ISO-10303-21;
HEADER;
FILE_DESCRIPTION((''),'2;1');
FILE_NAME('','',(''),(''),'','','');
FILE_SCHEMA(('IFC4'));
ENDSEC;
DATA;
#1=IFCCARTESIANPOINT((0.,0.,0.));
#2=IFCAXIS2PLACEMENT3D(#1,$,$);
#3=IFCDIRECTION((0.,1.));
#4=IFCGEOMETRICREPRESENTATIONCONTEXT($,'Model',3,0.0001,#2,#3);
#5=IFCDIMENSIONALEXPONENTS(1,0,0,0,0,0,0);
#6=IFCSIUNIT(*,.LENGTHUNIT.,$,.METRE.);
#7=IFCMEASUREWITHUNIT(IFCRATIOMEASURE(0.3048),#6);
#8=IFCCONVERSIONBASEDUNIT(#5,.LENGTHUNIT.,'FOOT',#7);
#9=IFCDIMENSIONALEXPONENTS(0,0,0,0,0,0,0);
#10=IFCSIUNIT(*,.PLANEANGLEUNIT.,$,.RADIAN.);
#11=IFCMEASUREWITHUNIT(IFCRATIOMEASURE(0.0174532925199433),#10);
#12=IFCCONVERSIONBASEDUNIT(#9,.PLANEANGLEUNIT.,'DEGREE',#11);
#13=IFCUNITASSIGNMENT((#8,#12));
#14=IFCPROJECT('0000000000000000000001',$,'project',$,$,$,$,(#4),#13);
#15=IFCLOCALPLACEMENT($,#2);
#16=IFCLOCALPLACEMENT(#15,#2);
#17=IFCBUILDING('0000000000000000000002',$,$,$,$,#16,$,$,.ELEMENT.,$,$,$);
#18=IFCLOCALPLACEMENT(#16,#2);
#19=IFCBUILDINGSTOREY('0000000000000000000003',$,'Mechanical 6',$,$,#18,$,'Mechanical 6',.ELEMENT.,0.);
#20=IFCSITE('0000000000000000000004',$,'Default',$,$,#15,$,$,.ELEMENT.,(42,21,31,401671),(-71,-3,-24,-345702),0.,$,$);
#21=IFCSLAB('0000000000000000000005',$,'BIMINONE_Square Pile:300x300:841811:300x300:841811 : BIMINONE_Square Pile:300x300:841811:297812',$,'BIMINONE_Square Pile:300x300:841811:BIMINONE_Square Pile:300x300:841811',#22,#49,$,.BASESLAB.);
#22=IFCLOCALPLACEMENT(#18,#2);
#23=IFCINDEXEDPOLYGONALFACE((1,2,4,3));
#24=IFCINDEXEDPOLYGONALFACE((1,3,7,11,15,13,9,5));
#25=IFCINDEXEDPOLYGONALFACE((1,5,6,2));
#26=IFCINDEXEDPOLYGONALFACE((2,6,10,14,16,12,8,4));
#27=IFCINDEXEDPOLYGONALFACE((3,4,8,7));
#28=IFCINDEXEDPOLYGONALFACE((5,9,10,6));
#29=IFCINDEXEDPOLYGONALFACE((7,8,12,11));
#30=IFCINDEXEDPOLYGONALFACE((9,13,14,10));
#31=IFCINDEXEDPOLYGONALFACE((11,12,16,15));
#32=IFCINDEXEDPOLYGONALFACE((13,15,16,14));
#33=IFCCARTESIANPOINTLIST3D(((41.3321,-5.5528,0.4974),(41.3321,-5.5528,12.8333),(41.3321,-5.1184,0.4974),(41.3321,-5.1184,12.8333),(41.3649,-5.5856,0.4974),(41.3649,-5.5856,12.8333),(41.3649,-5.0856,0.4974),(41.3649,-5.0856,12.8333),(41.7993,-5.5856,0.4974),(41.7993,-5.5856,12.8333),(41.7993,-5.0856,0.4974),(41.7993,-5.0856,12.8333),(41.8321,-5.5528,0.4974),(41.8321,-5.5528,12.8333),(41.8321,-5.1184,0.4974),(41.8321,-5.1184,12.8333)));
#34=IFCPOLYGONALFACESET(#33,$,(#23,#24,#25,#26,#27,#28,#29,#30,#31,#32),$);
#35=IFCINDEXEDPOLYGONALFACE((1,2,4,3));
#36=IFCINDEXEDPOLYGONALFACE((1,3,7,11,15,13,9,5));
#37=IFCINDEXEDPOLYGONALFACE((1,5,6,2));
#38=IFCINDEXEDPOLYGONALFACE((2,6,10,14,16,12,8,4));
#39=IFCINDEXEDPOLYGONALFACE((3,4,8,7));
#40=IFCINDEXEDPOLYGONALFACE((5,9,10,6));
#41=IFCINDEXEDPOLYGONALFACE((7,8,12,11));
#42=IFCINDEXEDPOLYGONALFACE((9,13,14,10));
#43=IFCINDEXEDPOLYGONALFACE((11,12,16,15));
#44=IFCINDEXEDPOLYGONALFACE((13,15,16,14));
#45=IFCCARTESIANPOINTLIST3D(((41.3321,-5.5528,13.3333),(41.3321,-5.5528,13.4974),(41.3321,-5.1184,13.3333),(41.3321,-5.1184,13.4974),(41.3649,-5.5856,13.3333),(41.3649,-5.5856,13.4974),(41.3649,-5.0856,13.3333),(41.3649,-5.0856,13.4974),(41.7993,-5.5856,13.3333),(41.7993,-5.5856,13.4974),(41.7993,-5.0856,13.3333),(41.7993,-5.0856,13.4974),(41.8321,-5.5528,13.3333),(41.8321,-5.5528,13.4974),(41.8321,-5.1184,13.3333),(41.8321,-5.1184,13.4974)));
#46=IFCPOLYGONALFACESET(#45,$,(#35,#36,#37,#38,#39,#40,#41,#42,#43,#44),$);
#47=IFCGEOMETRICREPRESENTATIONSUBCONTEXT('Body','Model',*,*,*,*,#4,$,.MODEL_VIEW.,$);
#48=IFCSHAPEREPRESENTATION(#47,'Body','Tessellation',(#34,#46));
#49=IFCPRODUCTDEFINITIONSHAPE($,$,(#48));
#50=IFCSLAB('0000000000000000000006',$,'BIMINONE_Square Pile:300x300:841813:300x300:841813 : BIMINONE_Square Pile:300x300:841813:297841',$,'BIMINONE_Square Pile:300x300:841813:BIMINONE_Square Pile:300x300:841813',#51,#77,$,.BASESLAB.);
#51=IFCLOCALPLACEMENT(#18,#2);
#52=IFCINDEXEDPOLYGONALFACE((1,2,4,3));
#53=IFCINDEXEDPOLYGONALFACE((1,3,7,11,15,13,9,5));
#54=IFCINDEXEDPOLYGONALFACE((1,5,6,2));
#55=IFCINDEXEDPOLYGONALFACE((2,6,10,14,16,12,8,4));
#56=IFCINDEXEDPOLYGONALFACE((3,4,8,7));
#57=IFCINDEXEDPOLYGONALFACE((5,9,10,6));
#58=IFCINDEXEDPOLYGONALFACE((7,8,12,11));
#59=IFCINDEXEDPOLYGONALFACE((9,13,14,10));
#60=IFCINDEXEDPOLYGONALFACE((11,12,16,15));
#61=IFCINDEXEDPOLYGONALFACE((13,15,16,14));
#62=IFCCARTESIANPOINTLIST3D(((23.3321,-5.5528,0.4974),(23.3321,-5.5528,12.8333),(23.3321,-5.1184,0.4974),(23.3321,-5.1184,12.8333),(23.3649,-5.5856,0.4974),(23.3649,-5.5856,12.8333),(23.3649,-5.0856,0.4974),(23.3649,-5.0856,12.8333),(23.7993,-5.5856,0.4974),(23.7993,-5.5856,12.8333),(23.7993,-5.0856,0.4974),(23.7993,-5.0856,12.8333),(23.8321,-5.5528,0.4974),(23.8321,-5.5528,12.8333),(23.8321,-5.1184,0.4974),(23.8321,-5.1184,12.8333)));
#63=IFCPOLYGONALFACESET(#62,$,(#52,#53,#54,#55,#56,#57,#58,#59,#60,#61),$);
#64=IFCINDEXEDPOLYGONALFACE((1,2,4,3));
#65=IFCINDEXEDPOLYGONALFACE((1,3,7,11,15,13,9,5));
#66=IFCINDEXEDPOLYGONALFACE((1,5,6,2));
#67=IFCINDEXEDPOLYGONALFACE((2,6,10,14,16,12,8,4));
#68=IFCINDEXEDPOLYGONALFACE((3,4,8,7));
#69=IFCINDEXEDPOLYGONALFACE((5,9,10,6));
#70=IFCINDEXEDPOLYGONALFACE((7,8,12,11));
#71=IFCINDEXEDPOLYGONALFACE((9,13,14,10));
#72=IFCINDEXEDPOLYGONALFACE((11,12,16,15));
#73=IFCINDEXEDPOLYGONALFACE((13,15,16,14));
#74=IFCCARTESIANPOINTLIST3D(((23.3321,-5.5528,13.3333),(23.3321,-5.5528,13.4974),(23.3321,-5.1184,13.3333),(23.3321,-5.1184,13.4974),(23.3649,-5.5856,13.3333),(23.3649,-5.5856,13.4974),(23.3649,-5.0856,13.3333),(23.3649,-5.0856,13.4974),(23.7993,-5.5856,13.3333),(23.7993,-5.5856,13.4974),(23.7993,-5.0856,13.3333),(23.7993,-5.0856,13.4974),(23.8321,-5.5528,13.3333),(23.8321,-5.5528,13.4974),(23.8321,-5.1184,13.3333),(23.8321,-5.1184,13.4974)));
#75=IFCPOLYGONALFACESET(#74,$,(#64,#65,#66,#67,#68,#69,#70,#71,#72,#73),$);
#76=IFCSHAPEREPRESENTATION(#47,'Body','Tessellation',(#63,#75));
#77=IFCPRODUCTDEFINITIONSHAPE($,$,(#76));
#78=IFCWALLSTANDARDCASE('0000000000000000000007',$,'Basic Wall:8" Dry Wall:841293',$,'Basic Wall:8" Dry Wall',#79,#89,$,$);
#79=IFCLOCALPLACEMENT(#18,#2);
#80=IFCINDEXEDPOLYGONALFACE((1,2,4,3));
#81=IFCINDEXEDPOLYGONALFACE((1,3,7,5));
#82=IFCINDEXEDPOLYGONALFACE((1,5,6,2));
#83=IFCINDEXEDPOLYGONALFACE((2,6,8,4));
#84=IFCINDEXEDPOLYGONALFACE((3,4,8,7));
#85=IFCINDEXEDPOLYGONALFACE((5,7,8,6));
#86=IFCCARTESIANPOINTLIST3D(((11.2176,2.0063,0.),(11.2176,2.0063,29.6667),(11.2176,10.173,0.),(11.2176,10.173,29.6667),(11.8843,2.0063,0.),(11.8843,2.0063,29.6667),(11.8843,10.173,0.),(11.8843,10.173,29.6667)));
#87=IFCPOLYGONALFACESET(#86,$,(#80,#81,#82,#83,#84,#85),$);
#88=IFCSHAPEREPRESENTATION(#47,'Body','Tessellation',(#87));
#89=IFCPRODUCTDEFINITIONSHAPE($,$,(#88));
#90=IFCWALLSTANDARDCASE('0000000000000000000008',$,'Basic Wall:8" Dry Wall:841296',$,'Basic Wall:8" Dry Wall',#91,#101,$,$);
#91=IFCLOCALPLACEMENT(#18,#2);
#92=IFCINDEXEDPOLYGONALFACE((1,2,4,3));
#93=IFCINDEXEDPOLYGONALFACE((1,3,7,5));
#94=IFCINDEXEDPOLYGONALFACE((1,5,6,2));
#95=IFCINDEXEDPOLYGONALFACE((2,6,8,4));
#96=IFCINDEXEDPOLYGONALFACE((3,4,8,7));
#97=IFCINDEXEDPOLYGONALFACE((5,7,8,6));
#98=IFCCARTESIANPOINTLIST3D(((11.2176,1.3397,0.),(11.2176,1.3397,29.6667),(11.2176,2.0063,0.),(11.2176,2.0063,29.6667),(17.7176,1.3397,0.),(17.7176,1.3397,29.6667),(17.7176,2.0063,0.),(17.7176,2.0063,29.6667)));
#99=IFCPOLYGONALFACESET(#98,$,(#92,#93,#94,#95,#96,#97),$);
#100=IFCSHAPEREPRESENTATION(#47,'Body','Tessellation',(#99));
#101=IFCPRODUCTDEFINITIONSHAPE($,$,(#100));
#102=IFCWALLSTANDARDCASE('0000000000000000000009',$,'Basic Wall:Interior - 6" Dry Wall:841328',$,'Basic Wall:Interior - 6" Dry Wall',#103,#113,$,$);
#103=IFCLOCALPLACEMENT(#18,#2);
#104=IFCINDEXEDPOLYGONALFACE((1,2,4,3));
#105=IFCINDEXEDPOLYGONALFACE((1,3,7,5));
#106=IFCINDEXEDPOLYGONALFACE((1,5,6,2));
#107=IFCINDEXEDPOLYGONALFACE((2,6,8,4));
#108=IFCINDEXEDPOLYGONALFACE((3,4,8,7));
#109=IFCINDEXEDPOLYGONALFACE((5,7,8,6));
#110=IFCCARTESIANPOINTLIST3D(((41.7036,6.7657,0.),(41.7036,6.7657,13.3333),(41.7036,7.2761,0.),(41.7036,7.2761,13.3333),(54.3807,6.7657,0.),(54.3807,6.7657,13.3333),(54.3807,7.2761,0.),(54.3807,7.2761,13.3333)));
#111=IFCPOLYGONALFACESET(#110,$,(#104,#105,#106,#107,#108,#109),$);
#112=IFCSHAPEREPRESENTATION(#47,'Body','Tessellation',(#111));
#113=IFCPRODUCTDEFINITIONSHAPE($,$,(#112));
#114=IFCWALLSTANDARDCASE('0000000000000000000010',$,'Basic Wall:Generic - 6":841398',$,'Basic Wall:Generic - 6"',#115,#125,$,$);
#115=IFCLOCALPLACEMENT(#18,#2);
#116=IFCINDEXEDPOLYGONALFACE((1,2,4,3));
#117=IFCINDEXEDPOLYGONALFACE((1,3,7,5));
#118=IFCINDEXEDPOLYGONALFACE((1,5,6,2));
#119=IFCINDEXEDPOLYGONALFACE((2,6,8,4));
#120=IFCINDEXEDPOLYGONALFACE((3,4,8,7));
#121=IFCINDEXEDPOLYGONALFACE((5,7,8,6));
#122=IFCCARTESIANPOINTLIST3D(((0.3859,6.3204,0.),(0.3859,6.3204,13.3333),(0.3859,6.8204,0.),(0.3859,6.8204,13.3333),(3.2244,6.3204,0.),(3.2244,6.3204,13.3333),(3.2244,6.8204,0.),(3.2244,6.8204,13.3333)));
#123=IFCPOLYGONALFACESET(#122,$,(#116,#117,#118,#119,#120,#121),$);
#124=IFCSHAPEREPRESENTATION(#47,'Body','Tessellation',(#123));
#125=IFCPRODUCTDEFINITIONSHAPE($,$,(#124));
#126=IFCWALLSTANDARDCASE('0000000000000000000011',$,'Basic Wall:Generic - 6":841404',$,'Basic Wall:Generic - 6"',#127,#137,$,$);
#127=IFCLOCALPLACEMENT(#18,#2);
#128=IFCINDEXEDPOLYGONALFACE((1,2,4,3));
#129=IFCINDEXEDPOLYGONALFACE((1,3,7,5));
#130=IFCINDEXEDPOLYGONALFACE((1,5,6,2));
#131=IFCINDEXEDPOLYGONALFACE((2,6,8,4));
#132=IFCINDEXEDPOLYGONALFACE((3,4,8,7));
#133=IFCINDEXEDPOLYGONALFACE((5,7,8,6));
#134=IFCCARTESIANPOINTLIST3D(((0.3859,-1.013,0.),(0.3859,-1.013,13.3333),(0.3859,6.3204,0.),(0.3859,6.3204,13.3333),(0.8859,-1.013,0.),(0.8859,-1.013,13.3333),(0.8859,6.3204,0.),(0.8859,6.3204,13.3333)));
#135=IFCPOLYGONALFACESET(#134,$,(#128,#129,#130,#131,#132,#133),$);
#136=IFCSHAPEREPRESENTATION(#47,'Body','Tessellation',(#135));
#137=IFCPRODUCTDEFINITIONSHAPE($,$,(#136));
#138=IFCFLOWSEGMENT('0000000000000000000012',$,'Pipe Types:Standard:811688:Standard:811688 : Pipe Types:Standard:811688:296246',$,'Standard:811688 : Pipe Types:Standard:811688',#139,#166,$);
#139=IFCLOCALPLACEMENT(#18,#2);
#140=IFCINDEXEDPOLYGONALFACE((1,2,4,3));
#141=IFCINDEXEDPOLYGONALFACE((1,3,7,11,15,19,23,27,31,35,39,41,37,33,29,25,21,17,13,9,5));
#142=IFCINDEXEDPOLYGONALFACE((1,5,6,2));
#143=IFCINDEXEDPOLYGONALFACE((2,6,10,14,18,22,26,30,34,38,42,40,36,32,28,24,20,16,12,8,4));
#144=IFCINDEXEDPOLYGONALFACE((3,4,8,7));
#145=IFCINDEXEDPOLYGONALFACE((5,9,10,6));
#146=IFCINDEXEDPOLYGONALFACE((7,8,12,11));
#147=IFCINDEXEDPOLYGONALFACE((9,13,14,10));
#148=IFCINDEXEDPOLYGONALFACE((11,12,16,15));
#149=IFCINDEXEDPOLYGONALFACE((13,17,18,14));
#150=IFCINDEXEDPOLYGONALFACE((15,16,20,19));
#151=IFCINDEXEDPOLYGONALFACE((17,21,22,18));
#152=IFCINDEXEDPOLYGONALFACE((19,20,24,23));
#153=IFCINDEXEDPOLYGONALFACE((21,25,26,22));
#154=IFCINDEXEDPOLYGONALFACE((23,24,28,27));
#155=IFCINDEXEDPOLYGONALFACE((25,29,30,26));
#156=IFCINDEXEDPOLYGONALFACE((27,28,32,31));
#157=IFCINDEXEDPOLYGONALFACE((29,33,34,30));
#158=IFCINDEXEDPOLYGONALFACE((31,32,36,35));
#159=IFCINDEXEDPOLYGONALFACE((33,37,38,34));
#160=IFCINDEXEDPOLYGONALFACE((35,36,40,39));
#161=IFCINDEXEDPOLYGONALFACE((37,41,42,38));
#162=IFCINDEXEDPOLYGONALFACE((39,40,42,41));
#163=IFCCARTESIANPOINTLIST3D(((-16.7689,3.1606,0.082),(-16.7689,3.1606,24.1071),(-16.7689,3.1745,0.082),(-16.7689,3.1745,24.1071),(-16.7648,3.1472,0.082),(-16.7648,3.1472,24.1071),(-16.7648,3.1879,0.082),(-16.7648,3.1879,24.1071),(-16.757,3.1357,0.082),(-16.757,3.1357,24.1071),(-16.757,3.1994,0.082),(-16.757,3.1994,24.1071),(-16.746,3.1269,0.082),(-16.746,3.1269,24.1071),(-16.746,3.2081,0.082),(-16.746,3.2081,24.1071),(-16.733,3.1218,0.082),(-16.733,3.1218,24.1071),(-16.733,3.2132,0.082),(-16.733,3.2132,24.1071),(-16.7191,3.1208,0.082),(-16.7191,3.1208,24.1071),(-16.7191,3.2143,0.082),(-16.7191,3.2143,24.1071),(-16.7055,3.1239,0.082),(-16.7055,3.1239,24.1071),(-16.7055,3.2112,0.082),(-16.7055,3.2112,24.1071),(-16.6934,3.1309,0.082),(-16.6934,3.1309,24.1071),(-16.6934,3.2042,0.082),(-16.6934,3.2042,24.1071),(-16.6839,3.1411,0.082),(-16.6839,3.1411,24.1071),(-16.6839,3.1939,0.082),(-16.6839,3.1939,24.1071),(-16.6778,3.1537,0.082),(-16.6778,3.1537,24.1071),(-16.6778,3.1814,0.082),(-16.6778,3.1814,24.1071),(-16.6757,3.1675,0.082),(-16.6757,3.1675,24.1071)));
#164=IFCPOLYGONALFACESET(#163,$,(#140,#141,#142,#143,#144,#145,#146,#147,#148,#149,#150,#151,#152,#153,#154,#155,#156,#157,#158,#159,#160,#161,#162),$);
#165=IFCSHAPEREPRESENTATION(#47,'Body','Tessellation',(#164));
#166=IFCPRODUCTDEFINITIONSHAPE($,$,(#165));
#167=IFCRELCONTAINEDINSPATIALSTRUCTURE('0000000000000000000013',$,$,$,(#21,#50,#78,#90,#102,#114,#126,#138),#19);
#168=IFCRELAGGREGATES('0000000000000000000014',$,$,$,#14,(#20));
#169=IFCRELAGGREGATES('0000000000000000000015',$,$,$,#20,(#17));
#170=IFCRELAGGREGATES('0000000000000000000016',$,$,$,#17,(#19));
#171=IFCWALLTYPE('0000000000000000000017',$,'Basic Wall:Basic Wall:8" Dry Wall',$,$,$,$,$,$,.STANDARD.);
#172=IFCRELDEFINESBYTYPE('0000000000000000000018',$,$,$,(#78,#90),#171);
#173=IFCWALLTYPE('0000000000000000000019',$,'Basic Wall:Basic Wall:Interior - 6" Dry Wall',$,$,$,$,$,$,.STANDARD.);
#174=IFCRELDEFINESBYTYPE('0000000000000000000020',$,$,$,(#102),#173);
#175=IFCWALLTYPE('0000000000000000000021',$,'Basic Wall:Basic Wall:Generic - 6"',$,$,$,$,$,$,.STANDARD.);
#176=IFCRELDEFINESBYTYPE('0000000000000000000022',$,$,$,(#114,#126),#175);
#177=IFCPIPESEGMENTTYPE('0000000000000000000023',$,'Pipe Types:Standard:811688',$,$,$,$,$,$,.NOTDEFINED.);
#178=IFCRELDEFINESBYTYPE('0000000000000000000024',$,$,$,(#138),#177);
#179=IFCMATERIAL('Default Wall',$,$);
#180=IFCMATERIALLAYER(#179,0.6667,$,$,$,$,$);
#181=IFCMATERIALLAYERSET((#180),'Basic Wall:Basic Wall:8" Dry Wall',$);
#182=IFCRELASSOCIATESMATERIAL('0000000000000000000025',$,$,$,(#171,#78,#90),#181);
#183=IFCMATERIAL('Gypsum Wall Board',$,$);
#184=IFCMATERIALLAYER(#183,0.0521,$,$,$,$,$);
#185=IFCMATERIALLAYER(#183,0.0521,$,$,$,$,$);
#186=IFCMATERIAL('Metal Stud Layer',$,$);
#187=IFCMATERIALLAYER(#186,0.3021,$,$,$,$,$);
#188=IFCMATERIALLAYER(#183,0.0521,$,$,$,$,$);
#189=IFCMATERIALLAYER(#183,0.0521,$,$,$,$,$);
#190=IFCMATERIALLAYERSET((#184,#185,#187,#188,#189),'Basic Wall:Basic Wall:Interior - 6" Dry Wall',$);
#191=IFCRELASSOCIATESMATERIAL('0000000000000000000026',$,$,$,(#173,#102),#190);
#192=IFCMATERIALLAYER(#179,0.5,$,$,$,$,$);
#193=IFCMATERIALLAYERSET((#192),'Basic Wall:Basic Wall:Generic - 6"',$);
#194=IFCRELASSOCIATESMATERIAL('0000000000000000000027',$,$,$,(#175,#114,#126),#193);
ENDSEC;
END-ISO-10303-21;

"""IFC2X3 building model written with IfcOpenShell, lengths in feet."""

from ifc_helpers import new_model, entity, si_unit, converted_unit, direction, frame, frame_2d, origin, origin_2d_with_axis, place, context, subcontext, project, spatial, polyline, rectangle, circle, outline, extrude, source, transform, mapped, material, layer, layer_set, layer_usage, type_object, type_shapes, element, save


model = new_model("IFC2X3")

# Units and contexts
model_context = context("Model", 3, precision=0.0001, world=origin(), true_north=direction((0.0, 1.0)))
body_context = subcontext(model_context, "Body", "Model", "MODEL_VIEW")
ifc_project = project(units=[converted_unit("LENGTHUNIT", "FOOT", entity("IfcRatioMeasure", 0.3048), si_unit("LENGTHUNIT", "METRE"), dimensions=[1, 0, 0, 0, 0, 0, 0]), converted_unit("PLANEANGLEUNIT", "DEGREE", entity("IfcRatioMeasure", 0.0174532925199433), si_unit("PLANEANGLEUNIT", "RADIAN"), dimensions=[0, 0, 0, 0, 0, 0, 0])], contexts=[model_context])

# Site, building, storey
site_placement = place(None, origin())
site = spatial("IfcSite", under=ifc_project, at=site_placement, Name="Default", CompositionType="ELEMENT", RefLatitude=(42, 21, 31, 401671), RefLongitude=(-71, -3, -24, -345702), RefElevation=0.0)
building_placement = place(site_placement, origin())
building = spatial("IfcBuilding", under=site, at=building_placement, CompositionType="ELEMENT")
storey_placement = place(building_placement, origin())
storey = spatial("IfcBuildingStorey", under=building, at=storey_placement, Name="Mechanical 6", LongName="Mechanical 6", CompositionType="ELEMENT", Elevation=0.0)

# Slabs
slab_1_placement = place(building_placement, origin())
element("IfcSlab", 1, at=slab_1_placement, inside=storey, Name="BIMINONE_Square Pile:300x300:841811:300x300:841811 : BIMINONE_Square Pile:300x300:841811:297812", ObjectType="BIMINONE_Square Pile:300x300:841811:BIMINONE_Square Pile:300x300:841811", PredefinedType="BASESLAB", context=body_context, shape_type="SweptSolid", body=[
    extrude(outline(polyline([(-0.0232, -0.3304), (0.0232, -0.3304), (0.3304, -0.0232), (0.3304, 0.0232), (0.0232, 0.3304), (-0.0232, 0.3304), (-0.3304, 0.0232), (-0.3304, -0.0232), (-0.0232, -0.3304)])), frame((41.5821, -5.3356, 0.4974), z_axis=(0.0, 0.0, 1.0), x_axis=(0.707107, -0.707107, 0.0)), (0.0, 0.0, 1.0), 12.336),
    extrude(outline(polyline([(-0.2172, -0.25), (0.2172, -0.25), (0.25, -0.2172), (0.25, 0.2172), (0.2172, 0.25), (-0.2172, 0.25), (-0.25, 0.2172), (-0.25, -0.2172), (-0.2172, -0.25)])), frame((41.5821, -5.3356, 13.3333)), (0.0, 0.0, 1.0), 0.164),
])
slab_2_placement = place(building_placement, origin())
element("IfcSlab", 2, at=slab_2_placement, inside=storey, Name="BIMINONE_Square Pile:300x300:841813:300x300:841813 : BIMINONE_Square Pile:300x300:841813:297841", ObjectType="BIMINONE_Square Pile:300x300:841813:BIMINONE_Square Pile:300x300:841813", PredefinedType="BASESLAB", context=body_context, shape_type="SweptSolid", body=[
    extrude(outline(polyline([(-0.0232, -0.3304), (0.0232, -0.3304), (0.3304, -0.0232), (0.3304, 0.0232), (0.0232, 0.3304), (-0.0232, 0.3304), (-0.3304, 0.0232), (-0.3304, -0.0232), (-0.0232, -0.3304)])), frame((23.5821, -5.3356, 0.4974), z_axis=(0.0, 0.0, 1.0), x_axis=(0.707107, -0.707107, 0.0)), (0.0, 0.0, 1.0), 12.336),
    extrude(outline(polyline([(-0.2172, -0.25), (0.2172, -0.25), (0.25, -0.2172), (0.25, 0.2172), (0.2172, 0.25), (-0.2172, 0.25), (-0.25, 0.2172), (-0.25, -0.2172), (-0.2172, -0.25)])), frame((23.5821, -5.3356, 13.3333)), (0.0, 0.0, 1.0), 0.164),
])

# Walls
ifc_material_1 = material(Name="Default Wall")
ifc_layer_1 = layer(ifc_material_1, 0.6667)
ifc_layer_set_1 = layer_set([ifc_layer_1], Name="Basic Wall:Basic Wall:8\" Dry Wall")
ifc_layer_usage_1 = layer_usage(ifc_layer_set_1, "AXIS2", "NEGATIVE", 0.3333)
wall_type_1 = type_object("IfcWallType", Name="Basic Wall:Basic Wall:8\" Dry Wall", PredefinedType="STANDARD", material=ifc_layer_set_1)
wall_1_placement = place(storey_placement, frame((11.5509, 2.0063, 0.0), z_axis=(0.0, 0.0, 1.0), x_axis=(0.0, 1.0, 0.0)))
element("IfcWallStandardCase", 3, at=wall_1_placement, inside=storey, type_object=wall_type_1, material=ifc_layer_usage_1, Name="Basic Wall:8\" Dry Wall:841293", ObjectType="Basic Wall:8\" Dry Wall", context=body_context, shape_type="SweptSolid", body=[
    extrude(rectangle(XDim=8.1667, YDim=0.6667, at=frame_2d((4.0833, 0.0), x_axis=(-1.0, 0.0))), origin(), (0.0, 0.0, 1.0), 29.6667),
])
ifc_layer_usage_2 = layer_usage(ifc_layer_set_1, "AXIS2", "NEGATIVE", 0.3333)
wall_2_placement = place(storey_placement, frame((17.7176, 1.673, 0.0), z_axis=(0.0, 0.0, 1.0), x_axis=(-1.0, 0.0, 0.0)))
element("IfcWallStandardCase", 4, at=wall_2_placement, inside=storey, type_object=wall_type_1, material=ifc_layer_usage_2, Name="Basic Wall:8\" Dry Wall:841296", ObjectType="Basic Wall:8\" Dry Wall", context=body_context, shape_type="SweptSolid", body=[
    extrude(rectangle(XDim=6.5, YDim=0.6667, at=frame_2d((3.25, 0.0), x_axis=(-1.0, 0.0))), origin(), (0.0, 0.0, 1.0), 29.6667),
])
ifc_material_2 = material(Name="Gypsum Wall Board")
ifc_layer_2 = layer(ifc_material_2, 0.0521)
ifc_layer_3 = layer(ifc_material_2, 0.0521)
ifc_material_3 = material(Name="Metal Stud Layer")
ifc_layer_4 = layer(ifc_material_3, 0.3021)
ifc_layer_5 = layer(ifc_material_2, 0.0521)
ifc_layer_6 = layer(ifc_material_2, 0.0521)
ifc_layer_set_2 = layer_set([ifc_layer_2, ifc_layer_3, ifc_layer_4, ifc_layer_5, ifc_layer_6], Name="Basic Wall:Basic Wall:Interior - 6\" Dry Wall")
ifc_layer_usage_3 = layer_usage(ifc_layer_set_2, "AXIS2", "NEGATIVE", 0.2552)
wall_type_2 = type_object("IfcWallType", Name="Basic Wall:Basic Wall:Interior - 6\" Dry Wall", PredefinedType="STANDARD", material=ifc_layer_set_2)
wall_3_placement = place(storey_placement, frame((54.3807, 7.0209, 0.0), z_axis=(0.0, 0.0, 1.0), x_axis=(-1.0, 0.0, 0.0)))
element("IfcWallStandardCase", 5, at=wall_3_placement, inside=storey, type_object=wall_type_2, material=ifc_layer_usage_3, Name="Basic Wall:Interior - 6\" Dry Wall:841328", ObjectType="Basic Wall:Interior - 6\" Dry Wall", context=body_context, shape_type="SweptSolid", body=[
    extrude(rectangle(XDim=12.6771, YDim=0.5104, at=frame_2d((6.3385, 0.0), x_axis=(-1.0, 0.0))), origin(), (0.0, 0.0, 1.0), 13.3333),
])
ifc_layer_7 = layer(ifc_material_1, 0.5)
ifc_layer_set_3 = layer_set([ifc_layer_7], Name="Basic Wall:Basic Wall:Generic - 6\"")
ifc_layer_usage_4 = layer_usage(ifc_layer_set_3, "AXIS2", "NEGATIVE", 0.25)
wall_type_3 = type_object("IfcWallType", Name="Basic Wall:Basic Wall:Generic - 6\"", PredefinedType="STANDARD", material=ifc_layer_set_3)
wall_4_placement = place(storey_placement, frame((3.2244, 6.5704, 0.0), z_axis=(0.0, 0.0, 1.0), x_axis=(-1.0, 0.0, 0.0)))
element("IfcWallStandardCase", 6, at=wall_4_placement, inside=storey, type_object=wall_type_3, material=ifc_layer_usage_4, Name="Basic Wall:Generic - 6\":841398", ObjectType="Basic Wall:Generic - 6\"", context=body_context, shape_type="SweptSolid", body=[
    extrude(rectangle(XDim=2.8385, YDim=0.5, at=frame_2d((1.4193, 0.0), x_axis=(-1.0, 0.0))), origin(), (0.0, 0.0, 1.0), 13.3333),
])
ifc_layer_usage_5 = layer_usage(ifc_layer_set_3, "AXIS2", "NEGATIVE", 0.25)
wall_5_placement = place(storey_placement, frame((0.6359, 6.3204, 0.0), z_axis=(0.0, 0.0, 1.0), x_axis=(0.0, -1.0, 0.0)))
element("IfcWallStandardCase", 7, at=wall_5_placement, inside=storey, type_object=wall_type_3, material=ifc_layer_usage_5, Name="Basic Wall:Generic - 6\":841404", ObjectType="Basic Wall:Generic - 6\"", context=body_context, shape_type="SweptSolid", body=[
    extrude(rectangle(XDim=7.3333, YDim=0.5, at=frame_2d((3.6667, 0.0), x_axis=(-1.0, 0.0))), origin(), (0.0, 0.0, 1.0), 13.3333),
])

# Flow segment
pipe_segment_type_1 = type_object("IfcPipeSegmentType", Name="Pipe Types:Standard:811688", PredefinedType="NOTDEFINED")
shared_shape_1 = source(origin(), body_context, "Body", "SweptSolid", [
    extrude(circle(Radius=0.0469, at=origin_2d_with_axis()), frame((-16.7226, 3.1675, 0.082)), (0.0, 0.0, 1.0), 24.0251),
])
type_shapes(pipe_segment_type_1, [shared_shape_1])
flow_segment_1_placement = place(building_placement, origin())
element("IfcFlowSegment", 8, at=flow_segment_1_placement, inside=storey, type_object=pipe_segment_type_1, Name="Pipe Types:Standard:811688:Standard:811688 : Pipe Types:Standard:811688:296246", ObjectType="Standard:811688 : Pipe Types:Standard:811688", context=body_context, shape_type="MappedRepresentation", body=[
    mapped(shared_shape_1, transform((0.0, 0.0, 0.0), scale=1.0)),
])

save(model, "model.ifc")
